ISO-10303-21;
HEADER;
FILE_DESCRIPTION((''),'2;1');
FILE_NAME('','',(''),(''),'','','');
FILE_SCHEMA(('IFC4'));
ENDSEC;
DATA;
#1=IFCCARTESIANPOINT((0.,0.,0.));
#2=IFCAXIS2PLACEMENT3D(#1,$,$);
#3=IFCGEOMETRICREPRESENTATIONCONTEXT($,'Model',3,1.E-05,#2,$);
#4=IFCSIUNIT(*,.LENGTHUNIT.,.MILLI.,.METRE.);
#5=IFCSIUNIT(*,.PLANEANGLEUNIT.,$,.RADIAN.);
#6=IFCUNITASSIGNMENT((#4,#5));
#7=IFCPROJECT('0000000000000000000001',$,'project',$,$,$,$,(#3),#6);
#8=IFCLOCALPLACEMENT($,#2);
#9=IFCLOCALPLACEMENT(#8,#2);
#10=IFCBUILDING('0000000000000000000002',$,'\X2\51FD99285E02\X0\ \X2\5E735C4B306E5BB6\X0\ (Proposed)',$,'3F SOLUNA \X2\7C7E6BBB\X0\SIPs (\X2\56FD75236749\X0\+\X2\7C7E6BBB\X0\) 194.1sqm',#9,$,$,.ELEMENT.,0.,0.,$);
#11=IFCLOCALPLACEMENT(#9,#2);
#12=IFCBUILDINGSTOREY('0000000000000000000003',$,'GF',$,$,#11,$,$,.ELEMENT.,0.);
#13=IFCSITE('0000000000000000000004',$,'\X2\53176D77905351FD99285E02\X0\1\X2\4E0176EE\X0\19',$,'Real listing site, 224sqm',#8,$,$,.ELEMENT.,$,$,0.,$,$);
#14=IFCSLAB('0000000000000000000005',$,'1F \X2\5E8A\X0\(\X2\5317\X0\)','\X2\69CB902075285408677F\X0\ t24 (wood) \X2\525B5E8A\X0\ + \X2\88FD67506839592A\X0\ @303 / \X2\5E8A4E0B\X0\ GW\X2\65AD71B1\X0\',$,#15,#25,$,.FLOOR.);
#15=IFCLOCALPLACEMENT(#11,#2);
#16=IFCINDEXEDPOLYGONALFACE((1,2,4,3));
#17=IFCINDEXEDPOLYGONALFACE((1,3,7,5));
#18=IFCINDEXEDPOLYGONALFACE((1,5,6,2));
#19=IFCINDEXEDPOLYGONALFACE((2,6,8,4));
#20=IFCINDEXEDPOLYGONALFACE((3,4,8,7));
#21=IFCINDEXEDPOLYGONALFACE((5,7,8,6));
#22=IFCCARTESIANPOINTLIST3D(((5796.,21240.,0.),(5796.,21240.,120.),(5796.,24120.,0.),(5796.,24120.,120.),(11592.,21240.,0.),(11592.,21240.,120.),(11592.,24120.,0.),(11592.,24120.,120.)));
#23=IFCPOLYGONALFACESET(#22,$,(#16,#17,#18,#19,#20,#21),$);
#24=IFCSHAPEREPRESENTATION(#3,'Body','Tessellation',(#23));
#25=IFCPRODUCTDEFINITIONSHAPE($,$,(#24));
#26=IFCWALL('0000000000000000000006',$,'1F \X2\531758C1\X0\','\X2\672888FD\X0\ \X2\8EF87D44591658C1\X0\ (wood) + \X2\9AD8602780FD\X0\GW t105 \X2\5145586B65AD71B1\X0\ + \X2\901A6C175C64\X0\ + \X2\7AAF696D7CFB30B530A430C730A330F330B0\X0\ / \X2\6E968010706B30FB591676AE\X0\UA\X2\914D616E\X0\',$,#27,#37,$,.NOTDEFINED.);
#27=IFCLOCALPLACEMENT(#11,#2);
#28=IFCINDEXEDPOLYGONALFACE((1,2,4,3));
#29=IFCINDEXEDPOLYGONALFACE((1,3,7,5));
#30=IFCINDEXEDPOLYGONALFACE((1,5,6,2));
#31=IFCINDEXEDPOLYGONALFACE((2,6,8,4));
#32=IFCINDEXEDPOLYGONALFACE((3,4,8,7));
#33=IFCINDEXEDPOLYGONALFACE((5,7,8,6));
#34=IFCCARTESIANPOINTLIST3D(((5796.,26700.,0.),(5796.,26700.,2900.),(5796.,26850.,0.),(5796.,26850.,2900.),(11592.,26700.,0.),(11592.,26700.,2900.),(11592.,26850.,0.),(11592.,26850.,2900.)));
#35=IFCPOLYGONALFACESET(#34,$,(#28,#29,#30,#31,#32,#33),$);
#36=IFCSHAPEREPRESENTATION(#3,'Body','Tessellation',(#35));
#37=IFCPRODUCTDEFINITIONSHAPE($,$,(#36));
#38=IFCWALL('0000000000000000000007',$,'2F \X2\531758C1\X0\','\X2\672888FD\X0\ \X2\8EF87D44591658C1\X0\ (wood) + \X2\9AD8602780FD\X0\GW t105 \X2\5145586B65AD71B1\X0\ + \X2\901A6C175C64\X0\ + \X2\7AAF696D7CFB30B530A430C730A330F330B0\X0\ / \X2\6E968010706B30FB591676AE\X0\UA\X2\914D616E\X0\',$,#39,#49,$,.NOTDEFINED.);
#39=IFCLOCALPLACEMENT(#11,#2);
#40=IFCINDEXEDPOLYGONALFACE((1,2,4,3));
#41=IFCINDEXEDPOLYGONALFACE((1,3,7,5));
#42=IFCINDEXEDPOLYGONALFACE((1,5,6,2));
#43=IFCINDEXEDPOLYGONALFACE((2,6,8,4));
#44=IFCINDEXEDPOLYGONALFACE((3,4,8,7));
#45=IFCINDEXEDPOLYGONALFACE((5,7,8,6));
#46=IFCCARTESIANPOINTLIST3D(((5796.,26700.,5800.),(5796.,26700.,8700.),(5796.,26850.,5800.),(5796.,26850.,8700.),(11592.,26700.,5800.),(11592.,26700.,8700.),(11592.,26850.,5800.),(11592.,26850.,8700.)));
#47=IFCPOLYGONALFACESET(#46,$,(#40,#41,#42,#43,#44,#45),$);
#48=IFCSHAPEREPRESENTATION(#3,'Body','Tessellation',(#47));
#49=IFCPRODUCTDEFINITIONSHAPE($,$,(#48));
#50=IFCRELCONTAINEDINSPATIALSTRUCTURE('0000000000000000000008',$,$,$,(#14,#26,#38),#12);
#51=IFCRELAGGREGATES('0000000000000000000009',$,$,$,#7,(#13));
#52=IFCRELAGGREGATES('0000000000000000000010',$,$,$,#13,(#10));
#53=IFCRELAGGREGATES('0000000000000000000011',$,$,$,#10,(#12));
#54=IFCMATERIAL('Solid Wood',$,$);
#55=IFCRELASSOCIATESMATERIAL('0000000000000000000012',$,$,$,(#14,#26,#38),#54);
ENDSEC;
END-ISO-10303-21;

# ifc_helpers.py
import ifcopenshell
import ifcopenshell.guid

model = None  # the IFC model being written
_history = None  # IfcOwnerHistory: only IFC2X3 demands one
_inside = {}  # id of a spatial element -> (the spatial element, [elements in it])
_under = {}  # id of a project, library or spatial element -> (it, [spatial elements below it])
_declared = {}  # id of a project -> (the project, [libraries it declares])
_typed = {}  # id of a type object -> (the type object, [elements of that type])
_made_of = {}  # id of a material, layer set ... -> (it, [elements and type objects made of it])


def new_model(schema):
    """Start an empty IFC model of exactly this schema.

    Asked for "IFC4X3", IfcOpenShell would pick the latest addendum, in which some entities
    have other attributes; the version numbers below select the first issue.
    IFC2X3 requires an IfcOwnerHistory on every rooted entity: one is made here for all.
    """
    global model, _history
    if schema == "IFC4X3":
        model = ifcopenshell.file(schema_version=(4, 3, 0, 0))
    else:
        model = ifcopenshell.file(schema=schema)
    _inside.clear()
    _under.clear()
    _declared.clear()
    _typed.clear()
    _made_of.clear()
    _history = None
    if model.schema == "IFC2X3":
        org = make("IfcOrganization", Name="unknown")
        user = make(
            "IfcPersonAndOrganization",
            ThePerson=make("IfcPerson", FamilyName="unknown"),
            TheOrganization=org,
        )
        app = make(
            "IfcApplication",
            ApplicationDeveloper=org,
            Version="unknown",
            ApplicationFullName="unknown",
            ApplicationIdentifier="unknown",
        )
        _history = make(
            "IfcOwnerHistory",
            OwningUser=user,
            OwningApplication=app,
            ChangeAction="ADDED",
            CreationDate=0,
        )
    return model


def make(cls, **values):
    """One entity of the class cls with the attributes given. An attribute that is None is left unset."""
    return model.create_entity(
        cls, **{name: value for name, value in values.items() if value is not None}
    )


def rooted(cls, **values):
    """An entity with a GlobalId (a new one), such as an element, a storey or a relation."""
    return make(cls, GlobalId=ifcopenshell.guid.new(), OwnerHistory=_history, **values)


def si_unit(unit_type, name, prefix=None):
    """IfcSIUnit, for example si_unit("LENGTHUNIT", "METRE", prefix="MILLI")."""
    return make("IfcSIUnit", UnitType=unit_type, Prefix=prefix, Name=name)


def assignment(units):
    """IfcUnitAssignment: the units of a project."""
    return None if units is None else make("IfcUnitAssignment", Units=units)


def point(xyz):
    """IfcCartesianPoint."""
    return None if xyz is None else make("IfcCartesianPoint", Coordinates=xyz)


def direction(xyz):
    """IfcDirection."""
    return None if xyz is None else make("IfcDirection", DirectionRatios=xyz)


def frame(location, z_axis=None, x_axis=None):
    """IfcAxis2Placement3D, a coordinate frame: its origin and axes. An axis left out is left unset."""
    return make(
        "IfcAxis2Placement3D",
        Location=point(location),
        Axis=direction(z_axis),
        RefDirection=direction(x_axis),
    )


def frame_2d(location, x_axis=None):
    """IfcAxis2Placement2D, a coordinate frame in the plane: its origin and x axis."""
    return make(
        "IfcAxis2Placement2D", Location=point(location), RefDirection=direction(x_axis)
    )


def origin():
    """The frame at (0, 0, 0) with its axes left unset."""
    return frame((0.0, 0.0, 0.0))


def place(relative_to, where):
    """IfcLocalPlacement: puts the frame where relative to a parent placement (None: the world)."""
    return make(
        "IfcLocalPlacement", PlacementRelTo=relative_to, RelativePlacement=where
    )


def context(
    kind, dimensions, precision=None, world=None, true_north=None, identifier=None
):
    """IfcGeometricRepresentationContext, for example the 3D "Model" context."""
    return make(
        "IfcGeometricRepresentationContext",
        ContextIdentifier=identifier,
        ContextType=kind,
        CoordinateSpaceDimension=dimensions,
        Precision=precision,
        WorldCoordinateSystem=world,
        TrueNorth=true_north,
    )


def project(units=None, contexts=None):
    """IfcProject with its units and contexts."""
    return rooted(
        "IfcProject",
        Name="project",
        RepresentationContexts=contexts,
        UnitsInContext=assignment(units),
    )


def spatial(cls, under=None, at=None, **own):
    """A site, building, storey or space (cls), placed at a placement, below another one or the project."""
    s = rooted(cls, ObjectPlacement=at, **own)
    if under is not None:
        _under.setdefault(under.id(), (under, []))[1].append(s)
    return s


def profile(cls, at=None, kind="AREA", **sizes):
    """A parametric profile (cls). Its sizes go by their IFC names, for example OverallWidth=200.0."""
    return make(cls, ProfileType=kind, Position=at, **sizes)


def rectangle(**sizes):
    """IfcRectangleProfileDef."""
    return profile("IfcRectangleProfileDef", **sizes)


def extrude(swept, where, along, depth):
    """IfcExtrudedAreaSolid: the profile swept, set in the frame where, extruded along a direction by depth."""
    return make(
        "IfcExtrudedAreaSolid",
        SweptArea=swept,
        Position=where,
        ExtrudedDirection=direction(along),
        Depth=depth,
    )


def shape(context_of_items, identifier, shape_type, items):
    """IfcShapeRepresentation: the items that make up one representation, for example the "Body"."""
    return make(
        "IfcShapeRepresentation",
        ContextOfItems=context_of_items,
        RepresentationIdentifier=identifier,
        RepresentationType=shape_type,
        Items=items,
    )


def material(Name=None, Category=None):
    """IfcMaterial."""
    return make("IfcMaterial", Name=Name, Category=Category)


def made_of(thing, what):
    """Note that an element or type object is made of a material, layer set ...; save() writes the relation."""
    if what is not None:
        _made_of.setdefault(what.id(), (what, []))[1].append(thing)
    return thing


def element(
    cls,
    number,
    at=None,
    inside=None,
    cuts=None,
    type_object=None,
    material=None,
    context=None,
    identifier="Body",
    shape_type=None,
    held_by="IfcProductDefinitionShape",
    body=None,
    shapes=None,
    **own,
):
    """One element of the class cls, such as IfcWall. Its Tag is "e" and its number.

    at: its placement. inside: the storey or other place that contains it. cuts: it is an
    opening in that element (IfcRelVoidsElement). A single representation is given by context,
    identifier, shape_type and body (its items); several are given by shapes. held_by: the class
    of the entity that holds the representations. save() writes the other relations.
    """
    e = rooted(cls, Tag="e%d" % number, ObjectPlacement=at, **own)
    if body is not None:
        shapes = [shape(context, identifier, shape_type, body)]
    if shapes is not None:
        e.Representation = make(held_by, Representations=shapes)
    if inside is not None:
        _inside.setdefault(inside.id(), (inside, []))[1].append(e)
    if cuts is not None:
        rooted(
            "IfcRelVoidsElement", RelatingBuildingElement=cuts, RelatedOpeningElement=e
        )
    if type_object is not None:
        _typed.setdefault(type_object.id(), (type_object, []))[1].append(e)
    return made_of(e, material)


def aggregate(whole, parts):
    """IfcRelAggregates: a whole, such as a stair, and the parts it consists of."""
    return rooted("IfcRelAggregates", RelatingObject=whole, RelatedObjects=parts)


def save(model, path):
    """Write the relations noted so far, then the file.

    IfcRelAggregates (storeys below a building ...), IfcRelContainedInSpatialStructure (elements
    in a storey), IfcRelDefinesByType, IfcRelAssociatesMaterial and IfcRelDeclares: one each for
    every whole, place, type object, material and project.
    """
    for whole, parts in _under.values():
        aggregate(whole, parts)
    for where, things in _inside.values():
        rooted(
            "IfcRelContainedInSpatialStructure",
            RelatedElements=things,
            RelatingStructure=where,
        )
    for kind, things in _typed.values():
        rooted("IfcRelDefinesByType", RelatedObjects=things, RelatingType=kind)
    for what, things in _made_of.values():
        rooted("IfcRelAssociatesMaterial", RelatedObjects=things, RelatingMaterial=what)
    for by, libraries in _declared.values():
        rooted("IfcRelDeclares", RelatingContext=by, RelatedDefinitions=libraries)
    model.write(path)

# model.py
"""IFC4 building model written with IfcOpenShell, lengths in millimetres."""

from ifc_helpers import new_model, si_unit, frame, frame_2d, origin, place, context, project, spatial, rectangle, extrude, material, element, save


model = new_model("IFC4")

# Units and contexts
model_context = context("Model", 3, precision=1e-05, world=origin())
ifc_project = project(units=[si_unit("LENGTHUNIT", "METRE", prefix="MILLI"), si_unit("PLANEANGLEUNIT", "RADIAN")], contexts=[model_context])

# Site, building, storey
site_placement = place(None, origin())
site = spatial("IfcSite", under=ifc_project, at=site_placement, Name="北海道函館市1丁目19", ObjectType="Real listing site, 224sqm", CompositionType="ELEMENT", RefElevation=0.0)
building_placement = place(site_placement, origin())
building = spatial("IfcBuilding", under=site, at=building_placement, Name="函館市 平屋の家 (Proposed)", ObjectType="3F SOLUNA 籾殻SIPs (国産杉+籾殻) 194.1sqm", CompositionType="ELEMENT", ElevationOfRefHeight=0.0, ElevationOfTerrain=0.0)
storey_placement = place(building_placement, origin())
storey = spatial("IfcBuildingStorey", under=building, at=storey_placement, Name="GF", CompositionType="ELEMENT", Elevation=0.0)

# Slab
ifc_material_1 = material(Name="Solid Wood")
slab_1_placement = place(storey_placement, frame((2898.0, 10620.0, 0.0)))
element("IfcSlab", 1, at=slab_1_placement, inside=storey, material=ifc_material_1, Name="1F 床(北)", Description="構造用合板 t24 (wood) 剛床 + 製材根太 @303 / 床下 GW断熱", PredefinedType="FLOOR", context=model_context, shape_type="SweptSolid", body=[
    extrude(rectangle(XDim=5796.0, YDim=2880.0, at=frame_2d((2898.0, 1440.0))), frame((2898.0, 10620.0, 0.0)), (0.0, 0.0, 1.0), 120.0),
])

# Wall
wall_1_placement = place(storey_placement, frame((2898.0, 13350.0, 0.0)))
element("IfcWall", 2, at=wall_1_placement, inside=storey, material=ifc_material_1, Name="1F 北壁", Description="木製 軸組外壁 (wood) + 高性能GW t105 充填断熱 + 通気層 + 窯業系サイディング / 準耐火・外皮UA配慮", PredefinedType="NOTDEFINED", context=model_context, shape_type="SweptSolid", body=[
    extrude(rectangle(XDim=5796.0, YDim=150.0, at=frame_2d((2898.0, 75.0))), frame((2898.0, 13350.0, 0.0)), (0.0, 0.0, 1.0), 2900.0),
])

# Wall
wall_2_placement = place(storey_placement, frame((2898.0, 13350.0, 2900.0)))
element("IfcWall", 3, at=wall_2_placement, inside=storey, material=ifc_material_1, Name="2F 北壁", Description="木製 軸組外壁 (wood) + 高性能GW t105 充填断熱 + 通気層 + 窯業系サイディング / 準耐火・外皮UA配慮", PredefinedType="NOTDEFINED", context=model_context, shape_type="SweptSolid", body=[
    extrude(rectangle(XDim=5796.0, YDim=150.0, at=frame_2d((2898.0, 75.0))), frame((2898.0, 13350.0, 2900.0)), (0.0, 0.0, 1.0), 2900.0),
])

save(model, "model.ifc")
